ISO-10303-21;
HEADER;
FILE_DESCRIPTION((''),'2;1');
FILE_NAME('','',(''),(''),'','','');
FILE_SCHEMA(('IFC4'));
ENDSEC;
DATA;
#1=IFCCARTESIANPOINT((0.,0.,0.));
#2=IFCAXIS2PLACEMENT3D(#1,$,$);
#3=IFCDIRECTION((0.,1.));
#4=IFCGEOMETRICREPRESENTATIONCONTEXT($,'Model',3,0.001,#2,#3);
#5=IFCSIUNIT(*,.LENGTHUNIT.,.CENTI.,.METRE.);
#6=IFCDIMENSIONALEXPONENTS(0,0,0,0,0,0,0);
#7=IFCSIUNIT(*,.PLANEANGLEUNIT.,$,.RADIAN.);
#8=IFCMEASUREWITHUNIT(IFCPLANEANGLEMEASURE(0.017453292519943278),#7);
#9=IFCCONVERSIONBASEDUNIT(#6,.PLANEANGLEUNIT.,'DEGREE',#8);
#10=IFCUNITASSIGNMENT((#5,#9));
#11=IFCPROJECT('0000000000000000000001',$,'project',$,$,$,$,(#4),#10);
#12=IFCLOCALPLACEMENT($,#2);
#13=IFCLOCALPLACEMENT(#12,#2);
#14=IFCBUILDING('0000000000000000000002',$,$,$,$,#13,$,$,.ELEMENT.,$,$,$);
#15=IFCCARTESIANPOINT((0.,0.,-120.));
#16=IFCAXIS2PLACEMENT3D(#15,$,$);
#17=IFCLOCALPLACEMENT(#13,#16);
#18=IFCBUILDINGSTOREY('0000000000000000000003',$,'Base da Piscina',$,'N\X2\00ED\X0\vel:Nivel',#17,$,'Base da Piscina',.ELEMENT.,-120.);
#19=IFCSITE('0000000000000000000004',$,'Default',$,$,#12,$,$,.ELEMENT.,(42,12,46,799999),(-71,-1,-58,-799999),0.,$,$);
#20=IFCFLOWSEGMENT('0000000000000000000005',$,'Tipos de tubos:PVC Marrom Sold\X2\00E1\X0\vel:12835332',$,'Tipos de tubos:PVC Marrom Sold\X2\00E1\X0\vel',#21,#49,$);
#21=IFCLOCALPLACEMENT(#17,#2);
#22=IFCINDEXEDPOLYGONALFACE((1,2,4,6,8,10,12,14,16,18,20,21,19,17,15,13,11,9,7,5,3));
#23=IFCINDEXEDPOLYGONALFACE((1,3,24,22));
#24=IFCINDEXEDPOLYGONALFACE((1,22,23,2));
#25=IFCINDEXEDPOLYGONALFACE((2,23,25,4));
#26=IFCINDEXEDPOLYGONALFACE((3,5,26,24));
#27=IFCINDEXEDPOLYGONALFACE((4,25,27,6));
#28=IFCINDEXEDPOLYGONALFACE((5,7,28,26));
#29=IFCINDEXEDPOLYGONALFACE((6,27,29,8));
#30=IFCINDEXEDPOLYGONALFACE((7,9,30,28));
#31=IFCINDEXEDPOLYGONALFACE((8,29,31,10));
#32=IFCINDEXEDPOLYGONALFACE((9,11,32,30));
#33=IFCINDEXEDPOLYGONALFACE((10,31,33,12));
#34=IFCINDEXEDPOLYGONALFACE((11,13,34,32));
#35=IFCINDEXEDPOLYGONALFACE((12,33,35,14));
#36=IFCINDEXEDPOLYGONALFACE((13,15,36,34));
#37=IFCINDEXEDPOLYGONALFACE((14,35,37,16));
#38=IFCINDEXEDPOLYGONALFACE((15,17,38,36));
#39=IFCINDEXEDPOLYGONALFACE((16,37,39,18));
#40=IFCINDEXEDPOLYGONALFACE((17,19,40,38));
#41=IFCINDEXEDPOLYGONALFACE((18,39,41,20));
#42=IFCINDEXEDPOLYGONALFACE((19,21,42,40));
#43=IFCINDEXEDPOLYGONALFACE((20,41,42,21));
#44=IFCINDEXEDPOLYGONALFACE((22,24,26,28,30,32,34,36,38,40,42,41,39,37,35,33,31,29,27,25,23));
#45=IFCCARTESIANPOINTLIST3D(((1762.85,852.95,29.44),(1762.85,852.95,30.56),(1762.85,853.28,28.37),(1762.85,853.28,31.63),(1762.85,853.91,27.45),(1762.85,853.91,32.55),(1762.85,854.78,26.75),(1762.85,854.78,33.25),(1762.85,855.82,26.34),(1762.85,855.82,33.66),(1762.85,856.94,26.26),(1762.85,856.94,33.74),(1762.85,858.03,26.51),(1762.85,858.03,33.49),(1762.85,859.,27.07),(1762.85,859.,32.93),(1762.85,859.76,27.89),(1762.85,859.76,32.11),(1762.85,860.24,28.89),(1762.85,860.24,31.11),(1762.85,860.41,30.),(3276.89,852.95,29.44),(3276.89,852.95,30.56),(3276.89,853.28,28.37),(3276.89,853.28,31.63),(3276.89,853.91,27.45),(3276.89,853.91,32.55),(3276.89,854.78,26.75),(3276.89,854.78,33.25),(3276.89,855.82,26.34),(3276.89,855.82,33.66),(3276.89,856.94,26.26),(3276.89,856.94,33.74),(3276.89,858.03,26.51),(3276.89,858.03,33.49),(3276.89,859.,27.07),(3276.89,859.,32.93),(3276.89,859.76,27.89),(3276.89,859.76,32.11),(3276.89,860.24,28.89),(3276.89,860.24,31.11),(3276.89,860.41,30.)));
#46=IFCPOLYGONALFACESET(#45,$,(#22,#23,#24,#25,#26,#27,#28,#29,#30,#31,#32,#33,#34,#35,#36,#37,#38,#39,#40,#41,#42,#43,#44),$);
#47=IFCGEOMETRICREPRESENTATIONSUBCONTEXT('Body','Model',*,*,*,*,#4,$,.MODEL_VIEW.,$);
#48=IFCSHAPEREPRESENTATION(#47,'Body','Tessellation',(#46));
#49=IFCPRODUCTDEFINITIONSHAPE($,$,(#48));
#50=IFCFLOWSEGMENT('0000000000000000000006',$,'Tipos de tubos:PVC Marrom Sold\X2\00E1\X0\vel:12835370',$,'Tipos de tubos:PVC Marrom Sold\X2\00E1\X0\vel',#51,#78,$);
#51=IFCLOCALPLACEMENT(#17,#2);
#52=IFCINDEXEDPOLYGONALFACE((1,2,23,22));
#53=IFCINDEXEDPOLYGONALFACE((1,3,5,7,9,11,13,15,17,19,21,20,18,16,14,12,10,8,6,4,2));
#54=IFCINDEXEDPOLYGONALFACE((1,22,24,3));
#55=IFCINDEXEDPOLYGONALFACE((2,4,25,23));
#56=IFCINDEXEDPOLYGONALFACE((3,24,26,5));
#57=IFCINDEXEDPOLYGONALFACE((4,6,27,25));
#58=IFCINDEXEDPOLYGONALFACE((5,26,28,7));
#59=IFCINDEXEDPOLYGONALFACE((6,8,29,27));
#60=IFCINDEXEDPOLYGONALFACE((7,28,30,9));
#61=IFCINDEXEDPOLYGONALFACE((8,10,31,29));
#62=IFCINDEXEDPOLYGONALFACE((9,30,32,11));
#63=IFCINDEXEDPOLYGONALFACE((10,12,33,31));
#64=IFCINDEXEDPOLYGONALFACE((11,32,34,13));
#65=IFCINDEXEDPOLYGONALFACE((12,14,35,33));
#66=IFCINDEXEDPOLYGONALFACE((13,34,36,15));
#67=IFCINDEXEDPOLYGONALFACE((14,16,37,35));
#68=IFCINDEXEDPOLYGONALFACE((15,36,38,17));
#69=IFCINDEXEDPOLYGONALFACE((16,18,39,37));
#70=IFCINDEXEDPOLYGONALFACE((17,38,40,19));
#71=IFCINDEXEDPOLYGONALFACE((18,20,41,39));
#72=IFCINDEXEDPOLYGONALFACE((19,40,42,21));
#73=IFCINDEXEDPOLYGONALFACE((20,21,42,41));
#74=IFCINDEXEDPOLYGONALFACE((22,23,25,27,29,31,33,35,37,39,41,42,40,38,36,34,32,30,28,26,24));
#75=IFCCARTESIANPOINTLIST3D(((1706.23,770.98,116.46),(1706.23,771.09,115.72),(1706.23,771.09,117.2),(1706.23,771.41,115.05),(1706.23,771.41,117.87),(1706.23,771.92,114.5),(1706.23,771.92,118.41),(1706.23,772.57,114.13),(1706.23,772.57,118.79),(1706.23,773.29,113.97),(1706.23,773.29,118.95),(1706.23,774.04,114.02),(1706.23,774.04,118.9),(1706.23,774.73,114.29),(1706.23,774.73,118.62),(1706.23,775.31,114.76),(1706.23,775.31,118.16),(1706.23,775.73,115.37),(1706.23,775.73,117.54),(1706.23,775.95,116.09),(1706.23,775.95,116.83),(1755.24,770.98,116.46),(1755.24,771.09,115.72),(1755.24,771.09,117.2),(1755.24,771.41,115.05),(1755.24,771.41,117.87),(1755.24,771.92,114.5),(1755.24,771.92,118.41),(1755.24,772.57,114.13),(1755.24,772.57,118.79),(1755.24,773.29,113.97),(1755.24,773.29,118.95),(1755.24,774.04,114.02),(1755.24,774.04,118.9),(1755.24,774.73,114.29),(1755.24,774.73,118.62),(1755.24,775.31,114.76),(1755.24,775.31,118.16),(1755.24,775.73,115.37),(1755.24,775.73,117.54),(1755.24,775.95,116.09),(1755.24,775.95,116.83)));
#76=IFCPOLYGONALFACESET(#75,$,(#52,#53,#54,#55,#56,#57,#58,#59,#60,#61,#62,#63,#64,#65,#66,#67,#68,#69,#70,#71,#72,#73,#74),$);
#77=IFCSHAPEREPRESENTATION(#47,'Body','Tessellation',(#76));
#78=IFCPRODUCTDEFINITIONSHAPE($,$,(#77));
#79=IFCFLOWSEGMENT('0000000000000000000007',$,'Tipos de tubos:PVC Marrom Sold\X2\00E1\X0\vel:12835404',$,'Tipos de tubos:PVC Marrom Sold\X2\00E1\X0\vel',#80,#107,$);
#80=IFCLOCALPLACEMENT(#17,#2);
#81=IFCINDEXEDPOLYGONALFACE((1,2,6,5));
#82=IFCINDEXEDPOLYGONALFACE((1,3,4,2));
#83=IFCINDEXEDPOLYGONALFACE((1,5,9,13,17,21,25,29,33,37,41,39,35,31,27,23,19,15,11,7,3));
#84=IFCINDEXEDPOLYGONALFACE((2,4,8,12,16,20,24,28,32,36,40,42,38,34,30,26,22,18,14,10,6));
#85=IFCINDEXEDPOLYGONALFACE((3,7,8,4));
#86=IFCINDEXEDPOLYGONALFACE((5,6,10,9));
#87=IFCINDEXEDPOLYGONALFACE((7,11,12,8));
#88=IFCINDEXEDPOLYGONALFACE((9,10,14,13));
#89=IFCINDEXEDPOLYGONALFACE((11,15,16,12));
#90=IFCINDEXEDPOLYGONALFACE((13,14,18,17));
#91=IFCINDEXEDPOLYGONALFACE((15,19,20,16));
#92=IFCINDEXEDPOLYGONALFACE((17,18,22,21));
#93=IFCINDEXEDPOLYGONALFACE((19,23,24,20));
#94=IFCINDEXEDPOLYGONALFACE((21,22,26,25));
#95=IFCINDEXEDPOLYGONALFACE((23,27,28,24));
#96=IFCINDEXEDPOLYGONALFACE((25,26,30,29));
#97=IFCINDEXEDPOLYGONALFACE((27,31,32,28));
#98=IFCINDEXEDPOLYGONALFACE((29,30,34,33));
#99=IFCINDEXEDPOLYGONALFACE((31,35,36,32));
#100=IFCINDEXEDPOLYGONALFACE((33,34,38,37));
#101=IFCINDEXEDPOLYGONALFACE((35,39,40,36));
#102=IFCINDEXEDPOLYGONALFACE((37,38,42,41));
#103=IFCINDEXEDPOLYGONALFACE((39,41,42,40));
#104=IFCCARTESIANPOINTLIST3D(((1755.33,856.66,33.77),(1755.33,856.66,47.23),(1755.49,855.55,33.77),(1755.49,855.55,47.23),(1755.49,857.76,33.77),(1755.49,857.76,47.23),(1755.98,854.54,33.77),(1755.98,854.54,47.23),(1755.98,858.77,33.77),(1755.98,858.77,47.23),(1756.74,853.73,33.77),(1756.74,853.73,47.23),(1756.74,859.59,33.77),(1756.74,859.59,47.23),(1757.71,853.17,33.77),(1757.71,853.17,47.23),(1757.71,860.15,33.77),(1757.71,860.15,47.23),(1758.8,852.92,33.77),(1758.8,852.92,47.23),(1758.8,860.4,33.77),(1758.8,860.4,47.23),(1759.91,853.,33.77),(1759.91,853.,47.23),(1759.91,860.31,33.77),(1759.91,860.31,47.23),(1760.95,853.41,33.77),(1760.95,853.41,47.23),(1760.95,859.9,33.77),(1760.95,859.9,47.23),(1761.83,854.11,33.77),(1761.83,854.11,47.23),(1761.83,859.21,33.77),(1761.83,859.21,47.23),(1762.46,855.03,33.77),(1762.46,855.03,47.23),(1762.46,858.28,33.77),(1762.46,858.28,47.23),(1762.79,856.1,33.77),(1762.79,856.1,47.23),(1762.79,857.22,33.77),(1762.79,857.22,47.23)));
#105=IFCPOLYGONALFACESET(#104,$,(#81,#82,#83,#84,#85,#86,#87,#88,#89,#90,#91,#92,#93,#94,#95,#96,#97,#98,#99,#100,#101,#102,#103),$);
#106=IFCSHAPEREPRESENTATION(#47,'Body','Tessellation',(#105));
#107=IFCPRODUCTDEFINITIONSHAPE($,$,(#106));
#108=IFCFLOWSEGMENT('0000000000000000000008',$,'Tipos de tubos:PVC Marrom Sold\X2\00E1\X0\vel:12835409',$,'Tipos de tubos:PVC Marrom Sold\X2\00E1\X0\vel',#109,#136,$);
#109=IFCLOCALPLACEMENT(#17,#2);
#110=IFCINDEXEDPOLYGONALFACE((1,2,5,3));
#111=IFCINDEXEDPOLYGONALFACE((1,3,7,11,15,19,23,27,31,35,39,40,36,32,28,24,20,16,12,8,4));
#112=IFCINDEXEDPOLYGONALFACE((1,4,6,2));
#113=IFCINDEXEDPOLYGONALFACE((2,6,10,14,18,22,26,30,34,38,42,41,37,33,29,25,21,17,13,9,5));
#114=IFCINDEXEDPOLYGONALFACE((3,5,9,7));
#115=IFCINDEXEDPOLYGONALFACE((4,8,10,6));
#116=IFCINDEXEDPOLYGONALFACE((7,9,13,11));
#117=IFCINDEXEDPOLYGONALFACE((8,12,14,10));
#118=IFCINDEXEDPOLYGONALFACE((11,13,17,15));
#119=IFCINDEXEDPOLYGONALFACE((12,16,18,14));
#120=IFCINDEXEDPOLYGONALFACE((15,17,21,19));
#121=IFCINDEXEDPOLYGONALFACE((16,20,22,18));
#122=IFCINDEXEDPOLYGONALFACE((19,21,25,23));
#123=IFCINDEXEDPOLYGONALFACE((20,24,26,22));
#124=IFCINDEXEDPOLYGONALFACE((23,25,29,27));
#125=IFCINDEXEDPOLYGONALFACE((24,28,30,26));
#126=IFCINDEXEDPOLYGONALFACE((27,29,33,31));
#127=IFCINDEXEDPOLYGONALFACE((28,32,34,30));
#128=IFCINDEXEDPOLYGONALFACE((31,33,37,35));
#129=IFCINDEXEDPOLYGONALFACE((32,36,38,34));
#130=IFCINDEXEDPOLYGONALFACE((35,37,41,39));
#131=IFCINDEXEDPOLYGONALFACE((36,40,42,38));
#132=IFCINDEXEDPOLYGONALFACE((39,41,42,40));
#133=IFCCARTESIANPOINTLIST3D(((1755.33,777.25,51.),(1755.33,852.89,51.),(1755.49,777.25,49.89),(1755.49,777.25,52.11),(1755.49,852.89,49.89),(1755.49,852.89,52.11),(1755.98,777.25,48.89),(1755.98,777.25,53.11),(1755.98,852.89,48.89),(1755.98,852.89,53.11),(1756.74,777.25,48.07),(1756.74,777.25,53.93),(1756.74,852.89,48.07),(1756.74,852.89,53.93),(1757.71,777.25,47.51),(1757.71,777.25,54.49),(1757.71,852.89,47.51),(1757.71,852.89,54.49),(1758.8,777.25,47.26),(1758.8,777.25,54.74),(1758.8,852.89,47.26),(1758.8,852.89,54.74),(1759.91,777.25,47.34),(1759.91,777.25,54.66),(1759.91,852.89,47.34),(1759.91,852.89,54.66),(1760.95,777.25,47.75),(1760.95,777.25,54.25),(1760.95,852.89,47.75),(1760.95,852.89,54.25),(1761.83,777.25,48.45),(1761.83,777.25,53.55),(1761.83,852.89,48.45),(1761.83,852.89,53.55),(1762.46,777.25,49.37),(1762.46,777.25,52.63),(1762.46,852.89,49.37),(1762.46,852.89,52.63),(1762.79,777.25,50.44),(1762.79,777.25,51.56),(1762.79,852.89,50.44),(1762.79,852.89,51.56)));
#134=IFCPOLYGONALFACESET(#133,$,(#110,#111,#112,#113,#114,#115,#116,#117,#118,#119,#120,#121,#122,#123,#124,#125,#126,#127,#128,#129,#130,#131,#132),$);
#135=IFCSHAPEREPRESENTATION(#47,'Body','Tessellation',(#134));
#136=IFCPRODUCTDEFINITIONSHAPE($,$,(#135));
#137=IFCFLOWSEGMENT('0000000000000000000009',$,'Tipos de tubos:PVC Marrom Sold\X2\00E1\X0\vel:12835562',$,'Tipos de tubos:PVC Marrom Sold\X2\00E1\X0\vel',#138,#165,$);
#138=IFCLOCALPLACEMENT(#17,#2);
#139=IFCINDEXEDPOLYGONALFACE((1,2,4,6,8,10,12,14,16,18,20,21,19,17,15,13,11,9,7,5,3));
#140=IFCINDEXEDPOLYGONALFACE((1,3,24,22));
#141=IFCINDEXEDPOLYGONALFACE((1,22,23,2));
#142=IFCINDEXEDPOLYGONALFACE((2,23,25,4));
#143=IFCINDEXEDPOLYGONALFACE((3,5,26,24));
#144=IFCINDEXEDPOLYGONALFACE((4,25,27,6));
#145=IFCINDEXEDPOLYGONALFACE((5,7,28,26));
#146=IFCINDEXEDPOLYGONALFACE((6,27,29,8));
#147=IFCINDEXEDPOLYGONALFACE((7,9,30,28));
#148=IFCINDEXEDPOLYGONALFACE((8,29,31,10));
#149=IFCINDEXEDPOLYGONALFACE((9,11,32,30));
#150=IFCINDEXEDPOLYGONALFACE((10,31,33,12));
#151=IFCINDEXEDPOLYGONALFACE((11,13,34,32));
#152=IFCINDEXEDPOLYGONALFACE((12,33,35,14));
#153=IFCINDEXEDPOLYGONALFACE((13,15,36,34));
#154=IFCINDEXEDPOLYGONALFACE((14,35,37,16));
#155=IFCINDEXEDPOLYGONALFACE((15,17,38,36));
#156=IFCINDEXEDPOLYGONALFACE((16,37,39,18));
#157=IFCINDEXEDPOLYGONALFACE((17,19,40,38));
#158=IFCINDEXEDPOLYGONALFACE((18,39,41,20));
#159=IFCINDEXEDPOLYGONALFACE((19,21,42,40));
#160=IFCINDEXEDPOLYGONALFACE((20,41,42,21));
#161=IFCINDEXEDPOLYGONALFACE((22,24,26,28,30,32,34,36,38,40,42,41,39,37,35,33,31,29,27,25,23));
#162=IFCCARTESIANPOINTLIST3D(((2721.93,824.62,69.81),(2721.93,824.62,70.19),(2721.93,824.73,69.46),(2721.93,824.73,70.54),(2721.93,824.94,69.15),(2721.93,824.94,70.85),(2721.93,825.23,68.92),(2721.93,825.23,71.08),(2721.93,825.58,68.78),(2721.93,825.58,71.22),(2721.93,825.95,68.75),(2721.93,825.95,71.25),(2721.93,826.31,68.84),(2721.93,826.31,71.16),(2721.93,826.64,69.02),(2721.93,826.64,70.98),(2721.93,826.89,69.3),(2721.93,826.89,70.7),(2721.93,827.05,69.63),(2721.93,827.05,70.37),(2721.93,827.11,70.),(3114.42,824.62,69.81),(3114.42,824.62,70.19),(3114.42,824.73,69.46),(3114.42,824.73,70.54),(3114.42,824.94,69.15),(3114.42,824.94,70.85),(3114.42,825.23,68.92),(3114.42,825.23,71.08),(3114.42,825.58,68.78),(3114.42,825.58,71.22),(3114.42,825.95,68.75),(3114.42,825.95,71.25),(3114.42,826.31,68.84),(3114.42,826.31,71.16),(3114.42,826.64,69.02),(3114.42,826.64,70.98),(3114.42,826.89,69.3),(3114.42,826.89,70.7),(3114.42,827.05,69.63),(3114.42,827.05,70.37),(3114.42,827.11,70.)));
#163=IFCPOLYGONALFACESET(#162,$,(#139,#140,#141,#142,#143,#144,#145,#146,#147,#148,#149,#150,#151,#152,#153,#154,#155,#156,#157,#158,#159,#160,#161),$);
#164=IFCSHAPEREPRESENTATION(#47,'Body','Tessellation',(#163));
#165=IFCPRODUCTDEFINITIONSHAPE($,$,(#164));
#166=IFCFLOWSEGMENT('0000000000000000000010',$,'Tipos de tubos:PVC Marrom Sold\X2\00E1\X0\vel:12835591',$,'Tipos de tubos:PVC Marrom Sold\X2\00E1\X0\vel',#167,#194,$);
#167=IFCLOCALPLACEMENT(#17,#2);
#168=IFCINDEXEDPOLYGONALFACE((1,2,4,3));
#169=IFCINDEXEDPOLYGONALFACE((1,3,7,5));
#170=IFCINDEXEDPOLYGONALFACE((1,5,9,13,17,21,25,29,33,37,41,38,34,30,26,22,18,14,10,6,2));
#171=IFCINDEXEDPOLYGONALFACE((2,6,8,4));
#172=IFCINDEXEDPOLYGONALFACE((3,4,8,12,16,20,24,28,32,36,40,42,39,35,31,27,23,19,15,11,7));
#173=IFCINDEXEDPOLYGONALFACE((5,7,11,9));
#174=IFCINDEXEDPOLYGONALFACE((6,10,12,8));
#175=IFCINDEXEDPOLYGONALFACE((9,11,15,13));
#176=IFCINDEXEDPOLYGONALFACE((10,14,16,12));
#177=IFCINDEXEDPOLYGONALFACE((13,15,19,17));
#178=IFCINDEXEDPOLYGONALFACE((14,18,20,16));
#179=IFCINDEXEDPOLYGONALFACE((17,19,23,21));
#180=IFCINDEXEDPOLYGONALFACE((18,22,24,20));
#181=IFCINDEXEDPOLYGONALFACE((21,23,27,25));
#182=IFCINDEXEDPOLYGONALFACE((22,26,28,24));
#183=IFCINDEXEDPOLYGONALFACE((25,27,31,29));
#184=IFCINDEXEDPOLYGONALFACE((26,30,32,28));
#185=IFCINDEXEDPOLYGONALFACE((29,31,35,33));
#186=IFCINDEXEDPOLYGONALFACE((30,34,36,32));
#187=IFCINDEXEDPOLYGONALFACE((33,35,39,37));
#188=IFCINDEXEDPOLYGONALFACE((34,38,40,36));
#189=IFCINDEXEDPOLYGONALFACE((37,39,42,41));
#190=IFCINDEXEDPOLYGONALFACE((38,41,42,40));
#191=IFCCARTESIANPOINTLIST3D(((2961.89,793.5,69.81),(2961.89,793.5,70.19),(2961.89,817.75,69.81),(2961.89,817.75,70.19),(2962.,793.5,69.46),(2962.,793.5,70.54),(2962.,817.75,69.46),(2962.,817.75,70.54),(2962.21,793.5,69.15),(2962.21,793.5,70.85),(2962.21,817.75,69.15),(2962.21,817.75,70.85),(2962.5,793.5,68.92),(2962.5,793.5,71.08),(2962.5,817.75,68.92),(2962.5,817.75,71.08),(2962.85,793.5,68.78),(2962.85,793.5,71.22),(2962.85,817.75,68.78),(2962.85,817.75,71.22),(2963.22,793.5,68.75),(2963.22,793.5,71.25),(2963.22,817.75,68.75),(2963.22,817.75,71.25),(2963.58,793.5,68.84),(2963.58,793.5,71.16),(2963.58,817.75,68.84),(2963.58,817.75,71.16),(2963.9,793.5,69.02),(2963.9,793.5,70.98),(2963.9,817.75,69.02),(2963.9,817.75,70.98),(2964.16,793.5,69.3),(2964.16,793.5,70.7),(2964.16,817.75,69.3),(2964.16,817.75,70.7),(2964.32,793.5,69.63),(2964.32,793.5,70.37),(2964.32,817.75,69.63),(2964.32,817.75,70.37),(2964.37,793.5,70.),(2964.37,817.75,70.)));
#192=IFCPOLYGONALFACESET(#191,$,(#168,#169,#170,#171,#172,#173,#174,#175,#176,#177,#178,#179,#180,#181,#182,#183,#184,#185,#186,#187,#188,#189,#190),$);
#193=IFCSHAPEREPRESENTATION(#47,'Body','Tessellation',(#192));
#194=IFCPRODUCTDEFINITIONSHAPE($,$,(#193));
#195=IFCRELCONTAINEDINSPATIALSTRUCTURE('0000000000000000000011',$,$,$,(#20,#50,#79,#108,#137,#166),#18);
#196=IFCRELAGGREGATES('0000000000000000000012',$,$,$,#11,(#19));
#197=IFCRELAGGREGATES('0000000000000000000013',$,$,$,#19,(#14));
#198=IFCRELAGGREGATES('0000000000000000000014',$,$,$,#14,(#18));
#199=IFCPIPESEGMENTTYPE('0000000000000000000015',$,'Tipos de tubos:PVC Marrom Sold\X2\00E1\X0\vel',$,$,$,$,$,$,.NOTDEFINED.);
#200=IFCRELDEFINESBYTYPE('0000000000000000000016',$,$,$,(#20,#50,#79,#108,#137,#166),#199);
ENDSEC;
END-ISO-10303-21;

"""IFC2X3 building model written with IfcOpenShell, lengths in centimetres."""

from ifc_helpers import new_model, entity, si_unit, converted_unit, direction, frame, frame_2d, origin, origin_2d_with_axis, place, context, subcontext, project, spatial, circle, extrude, type_object, element, save


model = new_model("IFC2X3")

# Units and contexts
model_context = context("Model", 3, precision=0.001, world=origin(), true_north=direction((0.0, 1.0)))
body_context = subcontext(model_context, "Body", "Model", "MODEL_VIEW")
ifc_project = project(units=[si_unit("LENGTHUNIT", "METRE", prefix="CENTI"), converted_unit("PLANEANGLEUNIT", "DEGREE", entity("IfcPlaneAngleMeasure", 0.017453292519943278), si_unit("PLANEANGLEUNIT", "RADIAN"), dimensions=[0, 0, 0, 0, 0, 0, 0])], contexts=[model_context])

# Site, building, storey
site_placement = place(None, origin())
site = spatial("IfcSite", under=ifc_project, at=site_placement, Name="Default", CompositionType="ELEMENT", RefLatitude=(42, 12, 46, 799999), RefLongitude=(-71, -1, -58, -799999), RefElevation=0.0)
building_placement = place(site_placement, origin())
building = spatial("IfcBuilding", under=site, at=building_placement, CompositionType="ELEMENT")
storey_placement = place(building_placement, frame((0.0, 0.0, -120.0)))
storey = spatial("IfcBuildingStorey", under=building, at=storey_placement, Name="Base da Piscina", ObjectType="Nível:Nivel", LongName="Base da Piscina", CompositionType="ELEMENT", Elevation=-120.0)

# Flow segments
pipe_segment_type = type_object("IfcPipeSegmentType", Name="Tipos de tubos:PVC Marrom Soldável", PredefinedType="NOTDEFINED")
flow_segment_1_placement = place(storey_placement, origin())
element("IfcFlowSegment", 1, at=flow_segment_1_placement, inside=storey, type_object=pipe_segment_type, Name="Tipos de tubos:PVC Marrom Soldável:12835332", ObjectType="Tipos de tubos:PVC Marrom Soldável", context=body_context, shape_type="SweptSolid", body=[
    extrude(circle(Radius=3.75, at=frame_2d((0.0, 0.0), x_axis=(1.0, 0.0))), frame((1762.85, 856.66, 30.0), z_axis=(1.0, 0.0, 0.0), x_axis=(0.0, 1.0, 0.0)), (0.0, 0.0, 1.0), 1514.04),
])
flow_segment_2_placement = place(storey_placement, origin())
element("IfcFlowSegment", 2, at=flow_segment_2_placement, inside=storey, type_object=pipe_segment_type, Name="Tipos de tubos:PVC Marrom Soldável:12835370", ObjectType="Tipos de tubos:PVC Marrom Soldável", context=body_context, shape_type="SweptSolid", body=[
    extrude(circle(Radius=2.5, at=frame_2d((0.0, 0.0), x_axis=(1.0, 0.0))), frame((1706.23, 773.48, 116.46), z_axis=(1.0, 0.0, 0.0), x_axis=(0.0, -1.0, 0.0)), (0.0, 0.0, 1.0), 49.02),
])
flow_segment_3_placement = place(storey_placement, origin())
element("IfcFlowSegment", 3, at=flow_segment_3_placement, inside=storey, type_object=pipe_segment_type, Name="Tipos de tubos:PVC Marrom Soldável:12835404", ObjectType="Tipos de tubos:PVC Marrom Soldável", context=body_context, shape_type="SweptSolid", body=[
    extrude(circle(Radius=3.75, at=origin_2d_with_axis()), frame((1759.08, 856.66, 33.77), z_axis=(0.0, 0.0, 1.0), x_axis=(-1.0, 0.0, 0.0)), (0.0, 0.0, 1.0), 13.46),
])
flow_segment_4_placement = place(storey_placement, origin())
element("IfcFlowSegment", 4, at=flow_segment_4_placement, inside=storey, type_object=pipe_segment_type, Name="Tipos de tubos:PVC Marrom Soldável:12835409", ObjectType="Tipos de tubos:PVC Marrom Soldável", context=body_context, shape_type="SweptSolid", body=[
    extrude(circle(Radius=3.75, at=origin_2d_with_axis()), frame((1759.08, 777.25, 51.0), z_axis=(0.0, 1.0, 0.0), x_axis=(-1.0, 0.0, 0.0)), (0.0, 0.0, 1.0), 75.64),
])
flow_segment_5_placement = place(storey_placement, origin())
element("IfcFlowSegment", 5, at=flow_segment_5_placement, inside=storey, type_object=pipe_segment_type, Name="Tipos de tubos:PVC Marrom Soldável:12835562", ObjectType="Tipos de tubos:PVC Marrom Soldável", context=body_context, shape_type="SweptSolid", body=[
    extrude(circle(Radius=1.25, at=frame_2d((0.0, 0.0), x_axis=(1.0, 0.0))), frame((2721.93, 825.86, 70.0), z_axis=(1.0, 0.0, 0.0), x_axis=(0.0, 1.0, 0.0)), (0.0, 0.0, 1.0), 392.49),
])
flow_segment_6_placement = place(storey_placement, origin())
element("IfcFlowSegment", 6, at=flow_segment_6_placement, inside=storey, type_object=pipe_segment_type, Name="Tipos de tubos:PVC Marrom Soldável:12835591", ObjectType="Tipos de tubos:PVC Marrom Soldável", context=body_context, shape_type="SweptSolid", body=[
    extrude(circle(Radius=1.25, at=origin_2d_with_axis()), frame((2963.12, 793.5, 70.0), z_axis=(0.0, 1.0, 0.0), x_axis=(1.0, 0.0, 0.0)), (0.0, 0.0, 1.0), 24.25),
])

save(model, "model.ifc")
